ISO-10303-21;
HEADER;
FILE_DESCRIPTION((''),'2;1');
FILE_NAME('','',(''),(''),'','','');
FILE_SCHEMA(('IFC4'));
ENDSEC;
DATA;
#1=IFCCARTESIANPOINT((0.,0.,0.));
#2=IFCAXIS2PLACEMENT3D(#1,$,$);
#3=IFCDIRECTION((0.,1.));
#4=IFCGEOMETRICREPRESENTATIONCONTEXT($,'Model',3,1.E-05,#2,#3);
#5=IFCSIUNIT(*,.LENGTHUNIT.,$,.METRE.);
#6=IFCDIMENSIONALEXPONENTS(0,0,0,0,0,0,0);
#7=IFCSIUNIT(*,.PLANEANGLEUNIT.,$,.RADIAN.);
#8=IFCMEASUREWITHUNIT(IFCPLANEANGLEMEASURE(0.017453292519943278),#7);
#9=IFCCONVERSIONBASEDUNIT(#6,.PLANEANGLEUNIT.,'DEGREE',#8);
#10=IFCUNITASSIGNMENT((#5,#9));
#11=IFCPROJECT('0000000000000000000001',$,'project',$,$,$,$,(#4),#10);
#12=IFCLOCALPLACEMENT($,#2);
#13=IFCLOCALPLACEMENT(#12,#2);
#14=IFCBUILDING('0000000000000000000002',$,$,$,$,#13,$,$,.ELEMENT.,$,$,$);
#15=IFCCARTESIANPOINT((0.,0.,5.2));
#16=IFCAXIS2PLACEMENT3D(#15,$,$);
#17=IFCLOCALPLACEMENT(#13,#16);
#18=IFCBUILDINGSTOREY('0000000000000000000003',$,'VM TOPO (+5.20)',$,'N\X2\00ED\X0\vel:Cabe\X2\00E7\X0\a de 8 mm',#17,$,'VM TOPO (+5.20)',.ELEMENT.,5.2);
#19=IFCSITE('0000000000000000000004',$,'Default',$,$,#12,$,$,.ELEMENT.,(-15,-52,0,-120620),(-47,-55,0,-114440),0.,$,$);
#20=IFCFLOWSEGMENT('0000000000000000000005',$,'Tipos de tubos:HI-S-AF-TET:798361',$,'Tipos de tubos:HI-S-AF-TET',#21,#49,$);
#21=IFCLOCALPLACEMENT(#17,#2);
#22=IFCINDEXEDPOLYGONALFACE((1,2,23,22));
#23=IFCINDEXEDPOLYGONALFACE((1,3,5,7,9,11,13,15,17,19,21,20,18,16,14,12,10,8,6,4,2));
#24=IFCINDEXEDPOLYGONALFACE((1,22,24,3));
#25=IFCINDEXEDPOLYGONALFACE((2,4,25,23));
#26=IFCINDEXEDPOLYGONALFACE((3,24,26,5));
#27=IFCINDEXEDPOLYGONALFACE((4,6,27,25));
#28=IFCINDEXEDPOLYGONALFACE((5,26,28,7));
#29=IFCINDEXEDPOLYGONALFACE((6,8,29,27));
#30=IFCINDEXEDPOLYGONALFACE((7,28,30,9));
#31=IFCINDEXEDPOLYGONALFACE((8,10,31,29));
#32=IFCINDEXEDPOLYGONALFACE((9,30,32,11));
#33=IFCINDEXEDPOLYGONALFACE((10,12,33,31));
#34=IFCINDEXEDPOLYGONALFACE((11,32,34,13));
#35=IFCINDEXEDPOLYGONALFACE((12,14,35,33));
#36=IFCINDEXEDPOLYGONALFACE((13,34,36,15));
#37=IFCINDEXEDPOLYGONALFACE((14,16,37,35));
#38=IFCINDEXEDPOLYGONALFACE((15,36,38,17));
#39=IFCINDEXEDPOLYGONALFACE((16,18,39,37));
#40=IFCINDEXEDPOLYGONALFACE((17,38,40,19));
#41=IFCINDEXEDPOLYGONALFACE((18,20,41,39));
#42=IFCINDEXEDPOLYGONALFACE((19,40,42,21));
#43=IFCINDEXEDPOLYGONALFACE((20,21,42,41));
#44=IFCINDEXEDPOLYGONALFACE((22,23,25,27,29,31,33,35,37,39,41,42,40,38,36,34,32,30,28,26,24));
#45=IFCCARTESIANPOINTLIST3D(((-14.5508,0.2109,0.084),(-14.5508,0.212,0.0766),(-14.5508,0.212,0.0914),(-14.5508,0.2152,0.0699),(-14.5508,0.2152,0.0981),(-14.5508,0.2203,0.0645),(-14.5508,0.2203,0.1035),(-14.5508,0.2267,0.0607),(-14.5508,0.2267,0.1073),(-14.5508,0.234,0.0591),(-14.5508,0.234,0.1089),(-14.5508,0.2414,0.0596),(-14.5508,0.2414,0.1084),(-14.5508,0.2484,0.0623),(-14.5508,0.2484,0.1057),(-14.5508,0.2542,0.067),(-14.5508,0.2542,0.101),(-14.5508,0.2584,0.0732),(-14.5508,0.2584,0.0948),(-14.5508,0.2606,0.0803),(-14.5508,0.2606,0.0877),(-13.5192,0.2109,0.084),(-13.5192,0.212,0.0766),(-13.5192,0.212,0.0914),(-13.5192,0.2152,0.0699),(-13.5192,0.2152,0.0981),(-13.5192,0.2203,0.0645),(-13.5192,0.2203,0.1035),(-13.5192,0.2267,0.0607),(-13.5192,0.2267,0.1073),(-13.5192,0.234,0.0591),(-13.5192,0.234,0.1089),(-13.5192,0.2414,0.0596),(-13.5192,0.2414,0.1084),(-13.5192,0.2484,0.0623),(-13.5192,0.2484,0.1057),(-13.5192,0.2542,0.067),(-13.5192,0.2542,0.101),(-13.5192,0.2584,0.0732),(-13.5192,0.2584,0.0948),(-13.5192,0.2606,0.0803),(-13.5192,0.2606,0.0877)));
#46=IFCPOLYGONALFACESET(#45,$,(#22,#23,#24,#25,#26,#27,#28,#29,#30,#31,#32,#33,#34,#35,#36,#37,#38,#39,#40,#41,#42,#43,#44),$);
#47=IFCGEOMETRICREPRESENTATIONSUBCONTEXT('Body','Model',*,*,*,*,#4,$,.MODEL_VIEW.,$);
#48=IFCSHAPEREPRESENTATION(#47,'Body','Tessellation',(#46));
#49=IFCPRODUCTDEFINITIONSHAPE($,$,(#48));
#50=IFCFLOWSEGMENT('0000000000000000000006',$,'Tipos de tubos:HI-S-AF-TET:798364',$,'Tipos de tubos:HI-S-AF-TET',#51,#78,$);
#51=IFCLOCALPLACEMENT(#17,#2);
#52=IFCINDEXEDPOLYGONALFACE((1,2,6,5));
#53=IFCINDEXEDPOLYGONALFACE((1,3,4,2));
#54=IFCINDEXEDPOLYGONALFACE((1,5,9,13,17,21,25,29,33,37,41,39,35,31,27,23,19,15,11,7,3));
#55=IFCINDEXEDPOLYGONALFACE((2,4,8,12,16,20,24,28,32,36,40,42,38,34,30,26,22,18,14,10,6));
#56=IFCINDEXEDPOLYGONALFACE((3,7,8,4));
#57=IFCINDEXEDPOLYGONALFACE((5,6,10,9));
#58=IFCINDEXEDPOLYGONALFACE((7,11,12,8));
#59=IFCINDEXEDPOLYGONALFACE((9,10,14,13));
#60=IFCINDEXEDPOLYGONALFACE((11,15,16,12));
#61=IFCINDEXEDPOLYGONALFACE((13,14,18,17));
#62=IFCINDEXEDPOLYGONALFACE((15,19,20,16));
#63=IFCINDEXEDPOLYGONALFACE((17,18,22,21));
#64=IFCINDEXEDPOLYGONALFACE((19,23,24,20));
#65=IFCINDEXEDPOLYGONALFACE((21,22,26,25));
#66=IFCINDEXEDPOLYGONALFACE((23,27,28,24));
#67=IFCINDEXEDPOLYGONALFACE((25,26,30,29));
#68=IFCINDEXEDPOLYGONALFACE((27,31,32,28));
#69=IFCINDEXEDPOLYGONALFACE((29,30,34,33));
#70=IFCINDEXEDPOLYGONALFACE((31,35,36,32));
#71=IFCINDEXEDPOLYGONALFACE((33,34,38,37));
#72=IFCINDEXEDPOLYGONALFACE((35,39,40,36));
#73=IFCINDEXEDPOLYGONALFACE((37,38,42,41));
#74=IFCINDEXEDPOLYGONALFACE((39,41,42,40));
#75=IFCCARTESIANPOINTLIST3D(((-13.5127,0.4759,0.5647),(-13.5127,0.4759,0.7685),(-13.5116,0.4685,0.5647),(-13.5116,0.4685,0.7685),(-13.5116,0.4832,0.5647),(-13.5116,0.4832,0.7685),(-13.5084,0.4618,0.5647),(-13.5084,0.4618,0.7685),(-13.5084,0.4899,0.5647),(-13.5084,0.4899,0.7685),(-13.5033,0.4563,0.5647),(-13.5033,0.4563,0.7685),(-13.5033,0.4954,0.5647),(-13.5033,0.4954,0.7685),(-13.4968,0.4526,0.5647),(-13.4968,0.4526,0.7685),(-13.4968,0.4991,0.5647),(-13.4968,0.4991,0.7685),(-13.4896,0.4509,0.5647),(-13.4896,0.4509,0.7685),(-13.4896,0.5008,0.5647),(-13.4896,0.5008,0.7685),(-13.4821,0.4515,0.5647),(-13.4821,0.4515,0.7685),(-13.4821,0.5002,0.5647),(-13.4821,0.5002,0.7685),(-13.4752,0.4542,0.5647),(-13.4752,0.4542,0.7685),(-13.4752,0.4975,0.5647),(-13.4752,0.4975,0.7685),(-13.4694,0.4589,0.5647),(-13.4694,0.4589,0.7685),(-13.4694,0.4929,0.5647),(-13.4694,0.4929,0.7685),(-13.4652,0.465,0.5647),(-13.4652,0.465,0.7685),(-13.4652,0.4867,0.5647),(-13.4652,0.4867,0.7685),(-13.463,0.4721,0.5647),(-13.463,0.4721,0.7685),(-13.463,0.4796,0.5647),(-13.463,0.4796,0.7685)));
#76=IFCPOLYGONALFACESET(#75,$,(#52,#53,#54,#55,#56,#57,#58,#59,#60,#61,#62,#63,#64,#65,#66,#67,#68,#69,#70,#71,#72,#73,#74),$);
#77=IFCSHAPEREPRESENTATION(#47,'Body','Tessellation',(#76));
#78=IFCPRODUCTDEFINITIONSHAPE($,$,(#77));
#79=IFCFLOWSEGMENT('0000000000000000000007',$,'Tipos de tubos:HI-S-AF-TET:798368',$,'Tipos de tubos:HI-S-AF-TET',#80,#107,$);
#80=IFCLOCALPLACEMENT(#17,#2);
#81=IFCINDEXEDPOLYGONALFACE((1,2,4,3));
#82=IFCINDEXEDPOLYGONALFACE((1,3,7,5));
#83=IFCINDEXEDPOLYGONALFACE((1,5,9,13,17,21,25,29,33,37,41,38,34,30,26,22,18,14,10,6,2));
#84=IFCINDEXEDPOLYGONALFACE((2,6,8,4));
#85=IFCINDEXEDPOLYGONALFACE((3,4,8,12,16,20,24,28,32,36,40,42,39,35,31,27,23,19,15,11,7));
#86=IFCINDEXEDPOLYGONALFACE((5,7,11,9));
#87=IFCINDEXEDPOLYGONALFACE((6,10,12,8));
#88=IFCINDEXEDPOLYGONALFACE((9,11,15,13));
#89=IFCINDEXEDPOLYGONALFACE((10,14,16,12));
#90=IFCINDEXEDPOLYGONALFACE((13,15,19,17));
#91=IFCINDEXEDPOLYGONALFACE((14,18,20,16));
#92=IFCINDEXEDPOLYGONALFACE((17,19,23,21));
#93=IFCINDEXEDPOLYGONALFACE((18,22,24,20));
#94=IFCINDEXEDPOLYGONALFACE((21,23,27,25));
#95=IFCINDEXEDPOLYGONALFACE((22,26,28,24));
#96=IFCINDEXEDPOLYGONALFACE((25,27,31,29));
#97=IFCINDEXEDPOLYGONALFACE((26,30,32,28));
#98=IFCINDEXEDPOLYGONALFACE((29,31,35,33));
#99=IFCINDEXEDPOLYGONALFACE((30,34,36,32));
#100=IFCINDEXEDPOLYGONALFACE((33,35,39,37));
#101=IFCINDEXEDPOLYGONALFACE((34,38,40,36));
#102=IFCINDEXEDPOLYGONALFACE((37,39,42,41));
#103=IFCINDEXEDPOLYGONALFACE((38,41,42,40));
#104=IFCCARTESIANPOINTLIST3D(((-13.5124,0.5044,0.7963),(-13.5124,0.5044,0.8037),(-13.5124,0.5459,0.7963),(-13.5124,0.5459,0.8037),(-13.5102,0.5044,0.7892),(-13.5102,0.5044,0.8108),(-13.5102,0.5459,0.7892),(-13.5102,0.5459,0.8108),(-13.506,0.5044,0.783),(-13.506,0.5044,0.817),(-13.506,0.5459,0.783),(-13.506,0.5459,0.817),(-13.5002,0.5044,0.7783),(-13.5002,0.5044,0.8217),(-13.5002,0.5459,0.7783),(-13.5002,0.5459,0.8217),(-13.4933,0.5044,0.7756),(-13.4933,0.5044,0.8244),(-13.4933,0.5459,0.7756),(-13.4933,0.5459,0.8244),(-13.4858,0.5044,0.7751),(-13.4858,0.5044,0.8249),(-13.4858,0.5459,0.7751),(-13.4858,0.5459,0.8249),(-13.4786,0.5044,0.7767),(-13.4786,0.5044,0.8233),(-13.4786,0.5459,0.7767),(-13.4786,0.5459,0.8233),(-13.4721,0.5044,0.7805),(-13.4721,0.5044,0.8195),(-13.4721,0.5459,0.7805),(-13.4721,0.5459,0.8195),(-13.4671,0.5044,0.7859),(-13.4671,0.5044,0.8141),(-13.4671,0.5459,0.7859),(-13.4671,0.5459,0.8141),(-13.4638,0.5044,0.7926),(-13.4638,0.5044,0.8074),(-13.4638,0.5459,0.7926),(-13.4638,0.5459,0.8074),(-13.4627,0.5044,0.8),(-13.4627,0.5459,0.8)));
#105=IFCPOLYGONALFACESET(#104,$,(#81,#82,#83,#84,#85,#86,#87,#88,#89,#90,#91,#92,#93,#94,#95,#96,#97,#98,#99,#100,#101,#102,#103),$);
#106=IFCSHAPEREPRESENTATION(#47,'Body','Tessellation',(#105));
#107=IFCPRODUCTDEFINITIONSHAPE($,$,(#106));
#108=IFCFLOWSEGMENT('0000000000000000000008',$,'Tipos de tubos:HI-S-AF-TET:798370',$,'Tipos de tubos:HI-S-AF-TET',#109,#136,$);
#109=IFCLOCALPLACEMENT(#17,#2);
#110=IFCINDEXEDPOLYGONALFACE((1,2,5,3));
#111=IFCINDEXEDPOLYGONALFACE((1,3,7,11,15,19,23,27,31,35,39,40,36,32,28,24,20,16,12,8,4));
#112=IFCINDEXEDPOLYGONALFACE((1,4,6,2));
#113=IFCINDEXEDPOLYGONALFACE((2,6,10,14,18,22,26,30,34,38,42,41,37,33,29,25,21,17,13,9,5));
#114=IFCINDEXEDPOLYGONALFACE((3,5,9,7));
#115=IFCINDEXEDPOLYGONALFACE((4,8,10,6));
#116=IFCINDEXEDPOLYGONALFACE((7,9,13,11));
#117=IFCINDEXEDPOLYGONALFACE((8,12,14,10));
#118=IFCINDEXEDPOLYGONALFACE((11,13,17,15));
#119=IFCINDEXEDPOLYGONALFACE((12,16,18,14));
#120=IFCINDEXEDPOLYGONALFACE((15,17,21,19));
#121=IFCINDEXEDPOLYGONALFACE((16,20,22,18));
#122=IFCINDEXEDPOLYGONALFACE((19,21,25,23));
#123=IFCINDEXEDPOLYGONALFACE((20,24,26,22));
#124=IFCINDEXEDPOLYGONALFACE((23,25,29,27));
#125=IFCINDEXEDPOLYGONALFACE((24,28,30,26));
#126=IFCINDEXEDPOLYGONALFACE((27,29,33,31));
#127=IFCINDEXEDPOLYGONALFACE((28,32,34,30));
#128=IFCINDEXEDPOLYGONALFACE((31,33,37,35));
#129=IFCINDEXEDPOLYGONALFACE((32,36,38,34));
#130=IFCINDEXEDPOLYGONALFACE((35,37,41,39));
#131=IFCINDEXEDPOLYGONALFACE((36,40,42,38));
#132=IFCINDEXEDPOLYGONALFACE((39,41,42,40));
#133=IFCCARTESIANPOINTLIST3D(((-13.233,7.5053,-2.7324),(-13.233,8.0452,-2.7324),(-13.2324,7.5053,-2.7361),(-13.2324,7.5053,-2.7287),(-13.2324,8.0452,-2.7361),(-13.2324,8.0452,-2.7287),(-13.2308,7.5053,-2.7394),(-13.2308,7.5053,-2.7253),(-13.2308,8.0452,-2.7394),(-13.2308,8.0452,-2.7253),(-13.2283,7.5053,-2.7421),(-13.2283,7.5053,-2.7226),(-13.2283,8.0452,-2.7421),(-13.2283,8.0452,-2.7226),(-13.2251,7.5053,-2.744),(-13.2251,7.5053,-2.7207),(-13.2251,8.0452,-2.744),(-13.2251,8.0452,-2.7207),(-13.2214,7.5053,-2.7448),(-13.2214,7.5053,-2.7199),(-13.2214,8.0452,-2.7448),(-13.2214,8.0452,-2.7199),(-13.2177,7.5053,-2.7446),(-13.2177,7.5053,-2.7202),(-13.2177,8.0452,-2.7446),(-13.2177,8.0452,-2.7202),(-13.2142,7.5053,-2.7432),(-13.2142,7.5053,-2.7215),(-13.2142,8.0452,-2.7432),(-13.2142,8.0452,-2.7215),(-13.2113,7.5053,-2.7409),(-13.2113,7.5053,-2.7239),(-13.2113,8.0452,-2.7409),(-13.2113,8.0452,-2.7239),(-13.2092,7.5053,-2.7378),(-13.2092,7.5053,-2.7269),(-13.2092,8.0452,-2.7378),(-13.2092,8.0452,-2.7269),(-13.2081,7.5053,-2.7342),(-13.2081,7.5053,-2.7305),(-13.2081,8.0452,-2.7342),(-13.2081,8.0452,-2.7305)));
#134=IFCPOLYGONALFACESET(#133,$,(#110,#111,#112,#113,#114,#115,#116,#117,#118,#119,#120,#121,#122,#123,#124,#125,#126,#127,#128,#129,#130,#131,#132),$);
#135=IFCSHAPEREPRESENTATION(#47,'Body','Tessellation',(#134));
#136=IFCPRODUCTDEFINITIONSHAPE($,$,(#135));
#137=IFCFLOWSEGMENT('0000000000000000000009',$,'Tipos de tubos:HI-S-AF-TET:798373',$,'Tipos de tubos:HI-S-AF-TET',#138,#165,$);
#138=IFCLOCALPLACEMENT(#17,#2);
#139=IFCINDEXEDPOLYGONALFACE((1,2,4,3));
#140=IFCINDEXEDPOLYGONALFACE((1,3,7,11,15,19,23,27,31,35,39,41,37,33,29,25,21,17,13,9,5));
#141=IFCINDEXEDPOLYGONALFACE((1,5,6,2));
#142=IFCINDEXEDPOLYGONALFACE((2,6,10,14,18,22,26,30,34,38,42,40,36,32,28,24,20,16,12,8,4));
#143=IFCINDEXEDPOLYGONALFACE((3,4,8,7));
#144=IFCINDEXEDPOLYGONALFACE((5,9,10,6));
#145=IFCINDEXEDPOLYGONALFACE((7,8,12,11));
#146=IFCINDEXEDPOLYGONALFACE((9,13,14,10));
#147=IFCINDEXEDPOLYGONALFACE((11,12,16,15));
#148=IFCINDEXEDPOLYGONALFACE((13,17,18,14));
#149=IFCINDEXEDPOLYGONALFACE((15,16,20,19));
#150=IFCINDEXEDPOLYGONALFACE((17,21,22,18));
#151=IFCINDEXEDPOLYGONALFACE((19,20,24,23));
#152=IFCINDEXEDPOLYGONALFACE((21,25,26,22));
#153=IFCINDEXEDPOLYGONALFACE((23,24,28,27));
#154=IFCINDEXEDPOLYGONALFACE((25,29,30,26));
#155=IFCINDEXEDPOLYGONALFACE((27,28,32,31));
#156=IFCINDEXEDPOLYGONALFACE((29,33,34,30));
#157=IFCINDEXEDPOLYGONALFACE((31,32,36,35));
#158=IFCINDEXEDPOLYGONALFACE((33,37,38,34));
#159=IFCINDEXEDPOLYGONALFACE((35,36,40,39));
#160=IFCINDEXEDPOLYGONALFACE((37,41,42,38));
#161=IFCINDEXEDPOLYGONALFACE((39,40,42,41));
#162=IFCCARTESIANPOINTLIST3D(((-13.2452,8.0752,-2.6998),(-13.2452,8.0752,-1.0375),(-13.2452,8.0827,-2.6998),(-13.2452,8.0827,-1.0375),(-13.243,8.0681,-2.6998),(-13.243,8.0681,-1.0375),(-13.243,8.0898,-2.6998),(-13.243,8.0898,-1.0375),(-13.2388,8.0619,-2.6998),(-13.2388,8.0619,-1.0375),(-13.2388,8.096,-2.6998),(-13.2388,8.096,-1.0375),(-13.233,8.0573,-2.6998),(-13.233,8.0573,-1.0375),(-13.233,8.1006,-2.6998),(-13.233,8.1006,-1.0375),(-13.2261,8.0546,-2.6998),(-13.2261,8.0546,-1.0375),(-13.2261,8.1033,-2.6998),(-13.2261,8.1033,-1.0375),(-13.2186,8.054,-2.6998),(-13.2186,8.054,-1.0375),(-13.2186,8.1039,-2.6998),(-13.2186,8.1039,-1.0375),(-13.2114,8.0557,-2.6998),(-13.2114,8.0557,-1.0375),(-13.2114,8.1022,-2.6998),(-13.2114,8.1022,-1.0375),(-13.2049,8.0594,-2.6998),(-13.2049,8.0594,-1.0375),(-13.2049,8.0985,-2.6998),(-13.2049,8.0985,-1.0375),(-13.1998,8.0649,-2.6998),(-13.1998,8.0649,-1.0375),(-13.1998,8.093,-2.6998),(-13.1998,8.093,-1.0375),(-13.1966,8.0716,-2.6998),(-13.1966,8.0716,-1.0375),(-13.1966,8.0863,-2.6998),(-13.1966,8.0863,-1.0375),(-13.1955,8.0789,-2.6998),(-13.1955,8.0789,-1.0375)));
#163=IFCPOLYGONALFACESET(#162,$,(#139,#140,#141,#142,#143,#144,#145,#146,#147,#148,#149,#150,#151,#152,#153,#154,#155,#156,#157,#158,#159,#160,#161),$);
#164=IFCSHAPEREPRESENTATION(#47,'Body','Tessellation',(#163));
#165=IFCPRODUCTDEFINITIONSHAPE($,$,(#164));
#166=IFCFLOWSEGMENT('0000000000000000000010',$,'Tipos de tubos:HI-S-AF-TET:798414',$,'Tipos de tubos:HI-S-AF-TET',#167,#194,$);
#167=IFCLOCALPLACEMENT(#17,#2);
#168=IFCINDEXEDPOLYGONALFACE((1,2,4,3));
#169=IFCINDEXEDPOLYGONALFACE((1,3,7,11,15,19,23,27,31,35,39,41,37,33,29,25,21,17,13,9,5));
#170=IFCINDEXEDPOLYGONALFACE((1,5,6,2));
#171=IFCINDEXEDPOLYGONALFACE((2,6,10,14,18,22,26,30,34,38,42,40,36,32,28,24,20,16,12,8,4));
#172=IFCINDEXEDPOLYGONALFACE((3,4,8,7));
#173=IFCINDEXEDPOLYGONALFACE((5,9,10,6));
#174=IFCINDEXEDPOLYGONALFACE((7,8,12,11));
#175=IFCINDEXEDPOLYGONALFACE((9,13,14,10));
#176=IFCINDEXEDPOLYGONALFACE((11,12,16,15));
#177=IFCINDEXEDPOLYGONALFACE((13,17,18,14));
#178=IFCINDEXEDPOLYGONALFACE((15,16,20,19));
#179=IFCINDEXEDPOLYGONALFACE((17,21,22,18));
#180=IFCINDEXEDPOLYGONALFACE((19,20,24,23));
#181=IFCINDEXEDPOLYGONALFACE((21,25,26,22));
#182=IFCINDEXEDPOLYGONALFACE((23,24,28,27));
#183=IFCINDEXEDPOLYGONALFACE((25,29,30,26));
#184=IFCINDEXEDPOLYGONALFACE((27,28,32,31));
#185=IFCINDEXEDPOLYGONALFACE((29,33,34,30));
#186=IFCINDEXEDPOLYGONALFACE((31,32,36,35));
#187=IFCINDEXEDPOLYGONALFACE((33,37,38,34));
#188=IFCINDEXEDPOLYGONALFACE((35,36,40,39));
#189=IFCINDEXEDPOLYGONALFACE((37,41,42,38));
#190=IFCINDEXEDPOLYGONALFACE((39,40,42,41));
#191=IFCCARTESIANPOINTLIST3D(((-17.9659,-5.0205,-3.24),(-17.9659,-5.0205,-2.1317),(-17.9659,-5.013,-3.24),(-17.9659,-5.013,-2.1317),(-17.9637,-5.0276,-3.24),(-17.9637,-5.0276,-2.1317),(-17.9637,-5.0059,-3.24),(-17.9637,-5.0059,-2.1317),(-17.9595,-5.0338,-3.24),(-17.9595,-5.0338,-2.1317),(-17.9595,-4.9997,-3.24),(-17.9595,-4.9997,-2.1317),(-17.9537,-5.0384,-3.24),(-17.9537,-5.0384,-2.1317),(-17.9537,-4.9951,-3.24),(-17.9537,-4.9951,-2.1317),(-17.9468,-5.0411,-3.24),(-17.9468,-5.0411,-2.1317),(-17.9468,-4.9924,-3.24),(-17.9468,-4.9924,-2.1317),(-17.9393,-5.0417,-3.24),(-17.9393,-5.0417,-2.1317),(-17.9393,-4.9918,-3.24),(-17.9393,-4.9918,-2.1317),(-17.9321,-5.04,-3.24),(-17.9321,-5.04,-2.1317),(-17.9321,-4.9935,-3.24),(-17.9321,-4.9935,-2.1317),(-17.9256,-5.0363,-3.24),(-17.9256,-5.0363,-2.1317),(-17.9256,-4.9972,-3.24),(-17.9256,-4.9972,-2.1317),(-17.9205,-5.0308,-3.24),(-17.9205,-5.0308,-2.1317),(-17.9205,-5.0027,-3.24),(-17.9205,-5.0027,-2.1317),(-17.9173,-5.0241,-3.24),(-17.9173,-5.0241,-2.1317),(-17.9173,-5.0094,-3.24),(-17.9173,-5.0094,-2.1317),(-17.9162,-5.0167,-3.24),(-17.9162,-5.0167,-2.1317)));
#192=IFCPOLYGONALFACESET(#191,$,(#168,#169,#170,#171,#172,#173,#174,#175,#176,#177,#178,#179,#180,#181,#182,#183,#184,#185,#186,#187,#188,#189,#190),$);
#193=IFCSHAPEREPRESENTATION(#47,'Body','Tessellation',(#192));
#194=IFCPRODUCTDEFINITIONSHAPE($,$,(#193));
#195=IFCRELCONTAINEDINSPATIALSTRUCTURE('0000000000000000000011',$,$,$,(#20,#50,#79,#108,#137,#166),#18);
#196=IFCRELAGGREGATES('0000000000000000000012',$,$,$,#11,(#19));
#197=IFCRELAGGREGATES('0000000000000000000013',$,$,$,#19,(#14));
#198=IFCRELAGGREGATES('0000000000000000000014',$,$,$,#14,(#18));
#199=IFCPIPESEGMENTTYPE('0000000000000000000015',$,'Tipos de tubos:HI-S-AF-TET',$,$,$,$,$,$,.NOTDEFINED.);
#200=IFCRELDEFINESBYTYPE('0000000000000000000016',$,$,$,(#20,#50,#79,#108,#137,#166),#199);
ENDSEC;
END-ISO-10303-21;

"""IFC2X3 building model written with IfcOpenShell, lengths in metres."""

from ifc_helpers import new_model, entity, si_unit, converted_unit, direction, frame, frame_2d, origin, origin_2d_with_axis, place, context, subcontext, project, spatial, circle, extrude, type_object, element, save


model = new_model("IFC2X3")

# Units and contexts
model_context = context("Model", 3, precision=1e-05, world=origin(), true_north=direction((0.0, 1.0)))
body_context = subcontext(model_context, "Body", "Model", "MODEL_VIEW")
ifc_project = project(units=[si_unit("LENGTHUNIT", "METRE"), converted_unit("PLANEANGLEUNIT", "DEGREE", entity("IfcPlaneAngleMeasure", 0.017453292519943278), si_unit("PLANEANGLEUNIT", "RADIAN"), dimensions=[0, 0, 0, 0, 0, 0, 0])], contexts=[model_context])

# Site, building, storey
site_placement = place(None, origin())
site = spatial("IfcSite", under=ifc_project, at=site_placement, Name="Default", CompositionType="ELEMENT", RefLatitude=(-15, -52, 0, -120620), RefLongitude=(-47, -55, 0, -114440), RefElevation=0.0)
building_placement = place(site_placement, origin())
building = spatial("IfcBuilding", under=site, at=building_placement, CompositionType="ELEMENT")
storey_placement = place(building_placement, frame((0.0, 0.0, 5.2)))
storey = spatial("IfcBuildingStorey", under=building, at=storey_placement, Name="VM TOPO (+5.20)", ObjectType="Nível:Cabeça de 8 mm", LongName="VM TOPO (+5.20)", CompositionType="ELEMENT", Elevation=5.2)

# Flow segments
pipe_segment_type_1 = type_object("IfcPipeSegmentType", Name="Tipos de tubos:HI-S-AF-TET", PredefinedType="NOTDEFINED")
flow_segment_1_placement = place(storey_placement, origin())
element("IfcFlowSegment", 1, at=flow_segment_1_placement, inside=storey, type_object=pipe_segment_type_1, Name="Tipos de tubos:HI-S-AF-TET:798361", ObjectType="Tipos de tubos:HI-S-AF-TET", context=body_context, shape_type="SweptSolid", body=[
    extrude(circle(Radius=0.025, at=frame_2d((0.0, 0.0), x_axis=(1.0, 0.0))), frame((-14.5508, 0.2359, 0.084), z_axis=(1.0, 0.0, 0.0), x_axis=(0.0, -1.0, 0.0)), (0.0, 0.0, 1.0), 1.0316),
])
flow_segment_2_placement = place(storey_placement, origin())
element("IfcFlowSegment", 2, at=flow_segment_2_placement, inside=storey, type_object=pipe_segment_type_1, Name="Tipos de tubos:HI-S-AF-TET:798364", ObjectType="Tipos de tubos:HI-S-AF-TET", context=body_context, shape_type="SweptSolid", body=[
    extrude(circle(Radius=0.025, at=origin_2d_with_axis()), frame((-13.4877, 0.4759, 0.5647), z_axis=(0.0, 0.0, 1.0), x_axis=(-1.0, 0.0, 0.0)), (0.0, 0.0, 1.0), 0.2038),
])
flow_segment_3_placement = place(storey_placement, origin())
element("IfcFlowSegment", 3, at=flow_segment_3_placement, inside=storey, type_object=pipe_segment_type_1, Name="Tipos de tubos:HI-S-AF-TET:798368", ObjectType="Tipos de tubos:HI-S-AF-TET", context=body_context, shape_type="SweptSolid", body=[
    extrude(circle(Radius=0.025, at=origin_2d_with_axis()), frame((-13.4877, 0.5044, 0.8), z_axis=(0.0, 1.0, 0.0), x_axis=(1.0, 0.0, 0.0)), (0.0, 0.0, 1.0), 0.0415),
])
flow_segment_4_placement = place(storey_placement, origin())
element("IfcFlowSegment", 4, at=flow_segment_4_placement, inside=storey, type_object=pipe_segment_type_1, Name="Tipos de tubos:HI-S-AF-TET:798370", ObjectType="Tipos de tubos:HI-S-AF-TET", context=body_context, shape_type="SweptSolid", body=[
    extrude(circle(Radius=0.0125, at=frame_2d((0.0, 0.0), x_axis=(1.0, 0.0))), frame((-13.2205, 7.5053, -2.7324), z_axis=(0.0, 1.0, 0.0), x_axis=(-1.0, 0.0, 0.0)), (0.0, 0.0, 1.0), 0.5399),
])
flow_segment_5_placement = place(storey_placement, origin())
element("IfcFlowSegment", 5, at=flow_segment_5_placement, inside=storey, type_object=pipe_segment_type_1, Name="Tipos de tubos:HI-S-AF-TET:798373", ObjectType="Tipos de tubos:HI-S-AF-TET", context=body_context, shape_type="SweptSolid", body=[
    extrude(circle(Radius=0.025, at=frame_2d((0.0, 0.0), x_axis=(1.0, 0.0))), frame((-13.2205, 8.0789, -2.6998)), (0.0, 0.0, 1.0), 1.6622),
])
flow_segment_6_placement = place(storey_placement, origin())
element("IfcFlowSegment", 6, at=flow_segment_6_placement, inside=storey, type_object=pipe_segment_type_1, Name="Tipos de tubos:HI-S-AF-TET:798414", ObjectType="Tipos de tubos:HI-S-AF-TET", context=body_context, shape_type="SweptSolid", body=[
    extrude(circle(Radius=0.025, at=origin_2d_with_axis()), frame((-17.9412, -5.0167, -3.24)), (0.0, 0.0, 1.0), 1.1083),
])

save(model, "model.ifc")
